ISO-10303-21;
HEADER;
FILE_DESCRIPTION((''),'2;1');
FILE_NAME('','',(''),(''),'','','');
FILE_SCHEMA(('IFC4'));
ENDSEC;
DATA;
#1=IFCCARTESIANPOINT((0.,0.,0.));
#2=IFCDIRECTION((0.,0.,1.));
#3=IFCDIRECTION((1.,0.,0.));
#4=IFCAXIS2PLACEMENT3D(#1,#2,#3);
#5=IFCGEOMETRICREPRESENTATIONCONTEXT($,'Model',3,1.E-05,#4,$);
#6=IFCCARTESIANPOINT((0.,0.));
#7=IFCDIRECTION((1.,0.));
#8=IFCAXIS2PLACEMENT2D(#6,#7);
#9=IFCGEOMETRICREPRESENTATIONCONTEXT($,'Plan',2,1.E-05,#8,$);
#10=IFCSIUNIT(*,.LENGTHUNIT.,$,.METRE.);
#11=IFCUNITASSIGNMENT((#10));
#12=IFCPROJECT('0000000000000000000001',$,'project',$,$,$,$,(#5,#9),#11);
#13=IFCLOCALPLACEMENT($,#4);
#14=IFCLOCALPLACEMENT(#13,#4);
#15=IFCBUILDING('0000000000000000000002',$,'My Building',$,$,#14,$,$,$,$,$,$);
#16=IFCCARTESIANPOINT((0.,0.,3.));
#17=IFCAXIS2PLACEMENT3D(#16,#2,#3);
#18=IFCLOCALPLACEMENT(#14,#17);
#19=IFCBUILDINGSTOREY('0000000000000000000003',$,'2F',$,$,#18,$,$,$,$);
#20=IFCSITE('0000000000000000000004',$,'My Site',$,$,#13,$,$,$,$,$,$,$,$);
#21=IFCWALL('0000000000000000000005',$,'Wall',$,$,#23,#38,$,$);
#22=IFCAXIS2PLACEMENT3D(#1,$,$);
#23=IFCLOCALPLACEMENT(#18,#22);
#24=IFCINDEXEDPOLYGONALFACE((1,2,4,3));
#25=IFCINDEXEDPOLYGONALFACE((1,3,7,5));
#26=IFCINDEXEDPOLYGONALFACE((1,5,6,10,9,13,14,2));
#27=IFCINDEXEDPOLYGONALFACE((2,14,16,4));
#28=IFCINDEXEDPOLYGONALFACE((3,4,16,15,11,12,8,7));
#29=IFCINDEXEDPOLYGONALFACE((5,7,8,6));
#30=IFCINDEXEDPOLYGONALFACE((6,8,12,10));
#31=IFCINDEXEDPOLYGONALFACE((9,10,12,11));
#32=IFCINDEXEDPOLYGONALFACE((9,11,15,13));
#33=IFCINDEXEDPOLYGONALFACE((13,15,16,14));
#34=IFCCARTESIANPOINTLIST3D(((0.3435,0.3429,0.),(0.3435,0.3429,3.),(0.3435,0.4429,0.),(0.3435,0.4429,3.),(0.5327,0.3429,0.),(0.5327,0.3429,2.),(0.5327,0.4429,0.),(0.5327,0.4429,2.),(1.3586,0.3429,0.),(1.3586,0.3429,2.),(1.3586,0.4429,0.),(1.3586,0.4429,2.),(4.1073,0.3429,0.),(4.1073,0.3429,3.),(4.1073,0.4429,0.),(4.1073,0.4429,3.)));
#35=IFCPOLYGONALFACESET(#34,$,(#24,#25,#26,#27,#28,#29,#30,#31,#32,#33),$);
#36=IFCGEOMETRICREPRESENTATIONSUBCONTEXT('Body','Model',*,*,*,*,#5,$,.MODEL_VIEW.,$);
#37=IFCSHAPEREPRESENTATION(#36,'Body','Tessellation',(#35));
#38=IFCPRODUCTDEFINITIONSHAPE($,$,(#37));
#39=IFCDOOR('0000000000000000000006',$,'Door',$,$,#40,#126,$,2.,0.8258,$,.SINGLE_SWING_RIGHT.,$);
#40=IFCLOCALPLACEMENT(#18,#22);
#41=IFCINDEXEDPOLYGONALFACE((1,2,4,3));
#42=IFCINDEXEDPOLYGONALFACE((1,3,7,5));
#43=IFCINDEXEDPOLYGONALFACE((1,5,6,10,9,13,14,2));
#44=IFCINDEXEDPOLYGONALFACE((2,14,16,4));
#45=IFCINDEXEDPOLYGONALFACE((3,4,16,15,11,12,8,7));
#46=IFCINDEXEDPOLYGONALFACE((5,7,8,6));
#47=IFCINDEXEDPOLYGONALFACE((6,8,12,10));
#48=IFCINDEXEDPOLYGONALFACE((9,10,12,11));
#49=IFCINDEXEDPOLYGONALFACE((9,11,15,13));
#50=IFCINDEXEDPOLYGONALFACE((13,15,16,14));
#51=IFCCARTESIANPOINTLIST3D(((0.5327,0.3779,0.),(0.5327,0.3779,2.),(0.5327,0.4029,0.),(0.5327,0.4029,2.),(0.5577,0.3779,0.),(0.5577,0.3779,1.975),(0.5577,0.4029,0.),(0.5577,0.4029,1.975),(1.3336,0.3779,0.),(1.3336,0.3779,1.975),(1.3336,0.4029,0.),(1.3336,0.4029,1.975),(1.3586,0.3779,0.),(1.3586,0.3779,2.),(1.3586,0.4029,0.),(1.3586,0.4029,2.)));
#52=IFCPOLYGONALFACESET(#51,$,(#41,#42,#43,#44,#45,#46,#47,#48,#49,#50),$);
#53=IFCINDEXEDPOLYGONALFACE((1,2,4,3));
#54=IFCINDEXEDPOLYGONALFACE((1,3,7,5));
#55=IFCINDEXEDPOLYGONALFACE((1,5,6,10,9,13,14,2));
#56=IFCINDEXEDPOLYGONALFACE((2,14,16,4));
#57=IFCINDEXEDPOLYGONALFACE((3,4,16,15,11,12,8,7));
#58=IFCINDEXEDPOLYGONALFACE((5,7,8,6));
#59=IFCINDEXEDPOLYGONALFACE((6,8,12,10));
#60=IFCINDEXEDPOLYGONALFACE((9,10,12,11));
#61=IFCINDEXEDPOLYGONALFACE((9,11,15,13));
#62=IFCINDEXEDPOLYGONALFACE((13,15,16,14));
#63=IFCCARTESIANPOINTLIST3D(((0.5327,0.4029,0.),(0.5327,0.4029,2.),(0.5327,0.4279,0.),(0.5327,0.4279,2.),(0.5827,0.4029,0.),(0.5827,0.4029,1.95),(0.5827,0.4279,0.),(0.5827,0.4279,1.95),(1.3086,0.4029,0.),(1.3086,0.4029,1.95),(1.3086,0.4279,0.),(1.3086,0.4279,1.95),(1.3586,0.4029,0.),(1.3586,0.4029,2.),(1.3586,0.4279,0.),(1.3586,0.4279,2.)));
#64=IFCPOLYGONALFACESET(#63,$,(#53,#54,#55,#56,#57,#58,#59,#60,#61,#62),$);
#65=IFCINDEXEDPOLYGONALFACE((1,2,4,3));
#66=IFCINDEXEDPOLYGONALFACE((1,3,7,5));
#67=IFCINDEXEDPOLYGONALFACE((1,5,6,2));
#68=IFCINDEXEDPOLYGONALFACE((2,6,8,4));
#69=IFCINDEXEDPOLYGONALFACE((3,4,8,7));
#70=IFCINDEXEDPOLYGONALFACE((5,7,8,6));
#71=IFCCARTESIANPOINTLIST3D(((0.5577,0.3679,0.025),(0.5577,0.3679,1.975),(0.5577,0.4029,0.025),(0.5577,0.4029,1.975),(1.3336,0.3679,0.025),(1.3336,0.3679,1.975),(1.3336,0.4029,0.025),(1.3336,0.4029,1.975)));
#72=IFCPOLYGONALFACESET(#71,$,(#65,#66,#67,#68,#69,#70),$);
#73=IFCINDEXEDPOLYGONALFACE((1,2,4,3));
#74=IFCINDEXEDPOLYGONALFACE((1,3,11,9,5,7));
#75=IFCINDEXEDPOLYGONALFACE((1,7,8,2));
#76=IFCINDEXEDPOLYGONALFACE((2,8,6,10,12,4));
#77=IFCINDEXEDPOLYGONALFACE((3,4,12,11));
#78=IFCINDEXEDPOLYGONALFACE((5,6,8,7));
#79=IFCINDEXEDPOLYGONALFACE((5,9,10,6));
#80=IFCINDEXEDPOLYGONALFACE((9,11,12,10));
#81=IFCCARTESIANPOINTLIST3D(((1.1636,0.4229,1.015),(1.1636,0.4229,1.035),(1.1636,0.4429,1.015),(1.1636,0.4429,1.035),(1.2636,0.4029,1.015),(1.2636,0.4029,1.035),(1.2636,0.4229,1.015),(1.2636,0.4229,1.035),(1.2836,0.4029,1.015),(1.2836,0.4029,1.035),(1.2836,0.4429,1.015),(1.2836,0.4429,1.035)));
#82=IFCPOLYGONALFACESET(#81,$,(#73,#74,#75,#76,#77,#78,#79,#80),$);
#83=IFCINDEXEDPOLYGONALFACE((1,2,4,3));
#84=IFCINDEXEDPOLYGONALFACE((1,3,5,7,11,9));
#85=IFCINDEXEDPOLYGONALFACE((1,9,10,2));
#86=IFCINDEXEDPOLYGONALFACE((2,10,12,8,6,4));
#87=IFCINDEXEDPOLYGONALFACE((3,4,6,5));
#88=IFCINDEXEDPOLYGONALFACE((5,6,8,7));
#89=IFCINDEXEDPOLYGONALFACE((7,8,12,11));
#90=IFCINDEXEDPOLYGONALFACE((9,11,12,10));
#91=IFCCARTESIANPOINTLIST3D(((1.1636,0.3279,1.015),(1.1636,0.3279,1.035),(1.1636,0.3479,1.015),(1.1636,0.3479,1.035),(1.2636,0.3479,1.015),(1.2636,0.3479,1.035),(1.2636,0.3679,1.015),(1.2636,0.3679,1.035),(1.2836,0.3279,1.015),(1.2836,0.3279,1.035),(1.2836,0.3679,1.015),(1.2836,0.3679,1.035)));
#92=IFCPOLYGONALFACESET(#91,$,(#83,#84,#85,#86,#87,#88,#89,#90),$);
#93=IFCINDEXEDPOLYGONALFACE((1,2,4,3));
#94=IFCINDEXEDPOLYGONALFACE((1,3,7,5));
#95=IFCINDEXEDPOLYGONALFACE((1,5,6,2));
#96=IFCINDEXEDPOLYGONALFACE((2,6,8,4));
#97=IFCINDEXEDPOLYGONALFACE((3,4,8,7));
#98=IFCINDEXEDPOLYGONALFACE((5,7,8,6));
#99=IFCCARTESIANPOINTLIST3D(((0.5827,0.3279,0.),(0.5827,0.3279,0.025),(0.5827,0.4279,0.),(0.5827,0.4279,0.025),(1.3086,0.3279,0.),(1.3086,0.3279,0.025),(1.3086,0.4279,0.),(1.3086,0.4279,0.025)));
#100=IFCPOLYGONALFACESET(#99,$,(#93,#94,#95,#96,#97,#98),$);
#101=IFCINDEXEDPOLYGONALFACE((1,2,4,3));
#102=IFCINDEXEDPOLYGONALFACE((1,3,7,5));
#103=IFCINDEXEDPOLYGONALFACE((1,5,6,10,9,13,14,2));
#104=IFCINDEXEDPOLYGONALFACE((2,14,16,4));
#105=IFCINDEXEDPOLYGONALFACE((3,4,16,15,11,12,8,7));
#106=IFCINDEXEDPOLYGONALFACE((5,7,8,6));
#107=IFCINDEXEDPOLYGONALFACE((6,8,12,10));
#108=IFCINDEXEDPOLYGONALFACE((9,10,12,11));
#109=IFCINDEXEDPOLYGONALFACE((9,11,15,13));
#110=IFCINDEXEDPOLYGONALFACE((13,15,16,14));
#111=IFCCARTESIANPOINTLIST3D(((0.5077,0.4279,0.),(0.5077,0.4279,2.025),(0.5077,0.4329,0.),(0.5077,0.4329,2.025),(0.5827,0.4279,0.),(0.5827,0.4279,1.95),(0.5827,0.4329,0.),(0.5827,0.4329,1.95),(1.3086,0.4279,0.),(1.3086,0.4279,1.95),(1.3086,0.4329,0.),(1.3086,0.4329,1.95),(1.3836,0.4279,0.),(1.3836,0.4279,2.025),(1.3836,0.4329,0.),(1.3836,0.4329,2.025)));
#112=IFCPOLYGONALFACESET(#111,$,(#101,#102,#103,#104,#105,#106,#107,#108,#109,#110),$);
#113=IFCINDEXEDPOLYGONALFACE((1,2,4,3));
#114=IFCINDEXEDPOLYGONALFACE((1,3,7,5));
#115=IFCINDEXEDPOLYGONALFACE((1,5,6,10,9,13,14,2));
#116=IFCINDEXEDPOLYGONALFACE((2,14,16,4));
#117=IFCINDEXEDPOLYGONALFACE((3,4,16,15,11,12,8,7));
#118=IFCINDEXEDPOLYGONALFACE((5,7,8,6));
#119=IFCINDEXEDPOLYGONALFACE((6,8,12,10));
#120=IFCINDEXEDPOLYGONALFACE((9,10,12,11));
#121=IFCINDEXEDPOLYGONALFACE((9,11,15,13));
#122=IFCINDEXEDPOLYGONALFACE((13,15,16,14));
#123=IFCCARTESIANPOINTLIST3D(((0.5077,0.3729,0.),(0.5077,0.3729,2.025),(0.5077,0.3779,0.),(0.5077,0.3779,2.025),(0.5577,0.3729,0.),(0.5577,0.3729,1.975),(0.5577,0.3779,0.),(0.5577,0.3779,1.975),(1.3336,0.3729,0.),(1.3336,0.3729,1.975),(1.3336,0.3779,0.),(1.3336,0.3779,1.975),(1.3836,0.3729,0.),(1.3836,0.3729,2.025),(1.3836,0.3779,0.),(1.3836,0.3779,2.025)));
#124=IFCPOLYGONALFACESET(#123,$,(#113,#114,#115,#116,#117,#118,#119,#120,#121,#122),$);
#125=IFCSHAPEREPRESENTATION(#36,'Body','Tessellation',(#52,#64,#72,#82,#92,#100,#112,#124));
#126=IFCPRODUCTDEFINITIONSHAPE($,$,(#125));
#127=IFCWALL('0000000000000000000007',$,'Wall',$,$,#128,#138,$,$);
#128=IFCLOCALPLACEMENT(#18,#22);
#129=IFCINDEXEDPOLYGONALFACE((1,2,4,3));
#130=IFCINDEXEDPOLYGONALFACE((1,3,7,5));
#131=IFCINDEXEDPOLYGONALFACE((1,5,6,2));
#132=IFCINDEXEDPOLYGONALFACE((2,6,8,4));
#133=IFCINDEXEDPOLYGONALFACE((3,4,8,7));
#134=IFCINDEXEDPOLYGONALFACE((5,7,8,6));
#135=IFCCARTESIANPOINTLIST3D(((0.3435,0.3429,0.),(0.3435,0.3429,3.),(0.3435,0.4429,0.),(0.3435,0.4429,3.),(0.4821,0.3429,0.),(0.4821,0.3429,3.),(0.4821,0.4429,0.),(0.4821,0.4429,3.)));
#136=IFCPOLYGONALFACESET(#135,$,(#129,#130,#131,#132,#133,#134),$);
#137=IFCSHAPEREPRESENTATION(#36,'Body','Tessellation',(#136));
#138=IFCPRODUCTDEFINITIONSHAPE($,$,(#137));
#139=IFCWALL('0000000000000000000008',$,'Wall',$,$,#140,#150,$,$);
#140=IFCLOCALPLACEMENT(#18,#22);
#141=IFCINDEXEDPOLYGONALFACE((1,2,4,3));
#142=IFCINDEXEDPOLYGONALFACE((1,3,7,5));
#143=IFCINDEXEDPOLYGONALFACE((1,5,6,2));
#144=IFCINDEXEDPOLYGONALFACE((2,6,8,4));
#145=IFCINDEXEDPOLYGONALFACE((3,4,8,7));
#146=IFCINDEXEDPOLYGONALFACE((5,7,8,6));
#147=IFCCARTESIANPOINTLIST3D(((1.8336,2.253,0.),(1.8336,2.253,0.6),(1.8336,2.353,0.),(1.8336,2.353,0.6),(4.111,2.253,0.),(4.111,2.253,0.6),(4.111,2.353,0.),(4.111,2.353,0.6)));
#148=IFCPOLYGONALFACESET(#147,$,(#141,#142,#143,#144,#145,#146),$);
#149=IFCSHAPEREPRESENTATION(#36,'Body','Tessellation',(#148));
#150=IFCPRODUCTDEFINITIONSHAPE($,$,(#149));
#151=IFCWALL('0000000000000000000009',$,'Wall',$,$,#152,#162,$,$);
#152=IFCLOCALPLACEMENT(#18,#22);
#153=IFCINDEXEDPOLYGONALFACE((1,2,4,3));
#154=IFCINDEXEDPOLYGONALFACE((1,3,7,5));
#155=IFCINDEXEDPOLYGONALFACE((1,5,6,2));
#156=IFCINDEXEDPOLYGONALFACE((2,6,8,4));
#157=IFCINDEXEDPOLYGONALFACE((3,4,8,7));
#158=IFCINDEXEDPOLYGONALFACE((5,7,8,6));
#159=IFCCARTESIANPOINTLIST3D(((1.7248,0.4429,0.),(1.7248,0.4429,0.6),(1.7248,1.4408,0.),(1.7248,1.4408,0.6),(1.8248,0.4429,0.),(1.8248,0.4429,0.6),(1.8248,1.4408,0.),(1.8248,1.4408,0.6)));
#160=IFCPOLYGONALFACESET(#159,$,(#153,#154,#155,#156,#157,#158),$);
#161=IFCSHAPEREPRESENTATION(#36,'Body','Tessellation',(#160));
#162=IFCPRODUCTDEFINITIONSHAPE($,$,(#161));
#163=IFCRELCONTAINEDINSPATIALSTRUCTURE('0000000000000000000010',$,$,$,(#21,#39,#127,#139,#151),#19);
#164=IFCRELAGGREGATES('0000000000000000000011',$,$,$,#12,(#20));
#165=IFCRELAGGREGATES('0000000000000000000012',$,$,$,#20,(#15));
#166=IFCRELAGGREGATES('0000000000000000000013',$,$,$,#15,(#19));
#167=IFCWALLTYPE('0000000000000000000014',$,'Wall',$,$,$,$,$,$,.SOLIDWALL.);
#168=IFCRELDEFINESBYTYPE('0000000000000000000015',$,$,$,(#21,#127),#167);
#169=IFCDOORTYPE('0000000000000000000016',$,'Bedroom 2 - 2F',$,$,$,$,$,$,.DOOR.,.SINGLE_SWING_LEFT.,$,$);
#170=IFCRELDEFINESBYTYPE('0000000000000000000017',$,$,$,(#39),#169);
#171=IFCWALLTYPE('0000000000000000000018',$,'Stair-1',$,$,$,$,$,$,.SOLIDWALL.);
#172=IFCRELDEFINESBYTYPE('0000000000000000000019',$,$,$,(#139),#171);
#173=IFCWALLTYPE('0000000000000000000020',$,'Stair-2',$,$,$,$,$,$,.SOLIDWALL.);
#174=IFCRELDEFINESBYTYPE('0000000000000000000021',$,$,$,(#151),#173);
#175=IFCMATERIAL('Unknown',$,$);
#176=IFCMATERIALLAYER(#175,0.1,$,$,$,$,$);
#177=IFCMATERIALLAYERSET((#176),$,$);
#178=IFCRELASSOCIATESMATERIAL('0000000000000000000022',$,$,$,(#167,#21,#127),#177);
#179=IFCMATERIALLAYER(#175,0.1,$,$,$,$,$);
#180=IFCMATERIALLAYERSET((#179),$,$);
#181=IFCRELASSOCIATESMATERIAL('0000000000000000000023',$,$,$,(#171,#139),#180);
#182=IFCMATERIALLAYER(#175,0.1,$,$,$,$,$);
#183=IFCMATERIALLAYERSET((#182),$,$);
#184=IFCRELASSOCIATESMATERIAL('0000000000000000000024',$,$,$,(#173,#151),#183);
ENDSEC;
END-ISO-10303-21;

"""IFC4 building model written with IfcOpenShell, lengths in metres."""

from ifc_helpers import new_model, entity, si_unit, frame, origin_with_axes, origin_2d_with_axis, place, context, subcontext, project, spatial, line, indexed_curve, outline, extrude, shape, source, transform, mapped, material, layer, layer_set, layer_usage, type_object, type_shapes, element, fill, save


model = new_model("IFC4")

# Units and contexts
model_context = context("Model", 3, precision=1e-05, world=origin_with_axes())
plan_context = context("Plan", 2, precision=1e-05, world=origin_2d_with_axis())
body_context_1 = subcontext(model_context, "Body", "Model", "MODEL_VIEW")
body_context_2 = subcontext(plan_context, "Body", "Plan", "PLAN_VIEW")
ifc_project = project(units=[si_unit("LENGTHUNIT", "METRE")], contexts=[model_context, plan_context])

# Site, building, storey
site_placement = place(None, origin_with_axes())
site = spatial("IfcSite", under=ifc_project, at=site_placement, Name="My Site")
building_placement = place(site_placement, origin_with_axes())
building = spatial("IfcBuilding", under=site, at=building_placement, Name="My Building")
storey_placement = place(building_placement, frame((0.0, 0.0, 3.0), z_axis=(0.0, 0.0, 1.0), x_axis=(1.0, 0.0, 0.0)))
storey = spatial("IfcBuildingStorey", under=building, at=storey_placement, Name="2F")

# Shared definitions
ifc_material = material(Name="Unknown")

# Shared definitions
ifc_layer_1 = layer(ifc_material, 0.1)
ifc_layer_set_1 = layer_set([ifc_layer_1])
wall_type_1 = type_object("IfcWallType", Name="Wall", PredefinedType="SOLIDWALL", material=ifc_layer_set_1)

# Wall, opening, door
ifc_layer_usage_1 = layer_usage(ifc_layer_set_1, "AXIS2", "POSITIVE", 0.0)
wall_1_placement = place(storey_placement, frame((4.2073, 0.4429, 0.0), z_axis=(0.0, 0.0, 1.0), x_axis=(-1.0, 0.0, 0.0)))
wall_1 = element("IfcWall", 1, at=wall_1_placement, inside=storey, type_object=wall_type_1, material=ifc_layer_usage_1, Name="Wall", context=body_context_1, shape_type="SweptSolid", body=[
    extrude(outline(indexed_curve([(0.1, 0.0), (0.1, 0.1), (3.8638, 0.1), (3.8638, 0.0)], segments=[line(1, 2, 3, 4, 1)])), origin_with_axes(), (0.0, 0.0, 1.0), 3.0),
])
shared_shape_1 = source(origin_with_axes(), body_context_1, "Body", "SweptSolid", [
    extrude(outline(indexed_curve([(0.0, 0.0), (0.8258, 0.0), (0.8258, 2.0), (0.0, 2.0)], segments=[line(1, 2, 3, 4, 1)])), frame((0.0, -0.6, 0.0), z_axis=(0.0, -1.0, 0.0), x_axis=(1.0, 0.0, 0.0)), (0.0, 0.0, -1.0), 1.2),
])
opening_1_placement = place(wall_1_placement, frame((2.8487, 0.015, 0.0), z_axis=(0.0, 0.0, 1.0), x_axis=(1.0, -0.000001, 0.0)))
opening_1 = element("IfcOpeningElement", 2, at=opening_1_placement, cuts=wall_1, PredefinedType="OPENING", context=body_context_1, shape_type="MappedRepresentation", body=[
    mapped(shared_shape_1, transform((0.0, 0.0, 0.0), x_axis=(1.0, 0.0, 0.0), y_axis=(0.0, 1.0, 0.0), z_axis=(0.0, 0.0, 1.0), scale=1.0)),
])
door_type_1 = type_object("IfcDoorType", Name="Bedroom 2 - 2F", OperationType="SINGLE_SWING_LEFT", PredefinedType="DOOR")
shared_shape_2 = source(origin_with_axes(), body_context_1, "Body", "SweptSolid", [
    extrude(outline(indexed_curve([(0.0, 0.0), (0.0, 2.0), (0.8258, 2.0), (0.8258, 0.0), (0.8008, 0.0), (0.8008, 1.975), (0.025, 1.975), (0.025, 0.0)], segments=[line(1, 2, 3, 4, 5, 6, 7, 8, 1)])), frame((0.0, 0.025, 0.0), z_axis=(0.0, -1.0, 0.0), x_axis=(1.0, 0.0, 0.0)), (0.0, 0.0, -1.0), 0.025),
    extrude(outline(indexed_curve([(0.0, 0.0), (0.0, 2.0), (0.8258, 2.0), (0.8258, 0.0), (0.7758, 0.0), (0.7758, 1.95), (0.05, 1.95), (0.05, 0.0)], segments=[line(1, 2, 3, 4, 5, 6, 7, 8, 1)])), frame((0.0, 0.0, 0.0), z_axis=(0.0, -1.0, 0.0), x_axis=(1.0, 0.0, 0.0)), (0.0, 0.0, -1.0), 0.025),
    extrude(outline(indexed_curve([(0.0, 0.0), (0.7758, 0.0), (0.7758, 0.035), (0.0, 0.035)], segments=[line(1, 2, 3, 4, 1)])), frame((0.025, 0.025, 0.025), z_axis=(0.0, 0.0, 1.0), x_axis=(1.0, 0.0, 0.0)), (0.0, 0.0, 1.0), 1.95),
    extrude(outline(indexed_curve([(0.0, 0.0), (0.0, -0.04), (0.12, -0.04), (0.12, -0.02), (0.02, -0.02), (0.02, 0.0)], segments=[line(1, 2, 3, 4, 5, 6, 1)])), frame((0.075, 0.025, 1.015), z_axis=(0.0, 0.0, 1.0), x_axis=(1.0, 0.0, 0.0)), (0.0, 0.0, 1.0), 0.02),
    extrude(outline(indexed_curve([(0.0, 0.0), (0.0, 0.04), (0.12, 0.04), (0.12, 0.02), (0.02, 0.02), (0.02, 0.0)], segments=[line(1, 2, 3, 4, 5, 6, 1)])), frame((0.075, 0.06, 1.015), z_axis=(0.0, 0.0, 1.0), x_axis=(1.0, 0.0, 0.0)), (0.0, 0.0, 1.0), 0.02),
    extrude(outline(indexed_curve([(0.0, 0.0), (0.7258, 0.0), (0.7258, 0.1), (0.0, 0.1)], segments=[line(1, 2, 3, 4, 1)])), frame((0.05, 0.0, 0.0), z_axis=(0.0, 0.0, 1.0), x_axis=(1.0, 0.0, 0.0)), (0.0, 0.0, 1.0), 0.025),
    extrude(outline(indexed_curve([(0.0, 0.0), (0.0, 2.025), (0.8758, 2.025), (0.8758, 0.0), (0.8008, 0.0), (0.8008, 1.95), (0.075, 1.95), (0.075, 0.0)], segments=[line(1, 2, 3, 4, 5, 6, 7, 8, 1)])), frame((-0.025, -0.005, 0.0), z_axis=(0.0, -1.0, 0.0), x_axis=(1.0, 0.0, 0.0)), (0.0, 0.0, -1.0), 0.005),
    extrude(outline(indexed_curve([(0.0, 0.0), (0.0, 2.025), (0.8758, 2.025), (0.8758, 0.0), (0.8258, 0.0), (0.8258, 1.975), (0.05, 1.975), (0.05, 0.0)], segments=[line(1, 2, 3, 4, 5, 6, 7, 8, 1)])), frame((-0.025, 0.05, 0.0), z_axis=(0.0, -1.0, 0.0), x_axis=(1.0, 0.0, 0.0)), (0.0, 0.0, -1.0), 0.005),
])
shared_shape_3 = source(origin_with_axes(), body_context_2, "Body", "Curve2D", [
    entity("IfcIndexedPolyCurve", entity("IfcCartesianPointList2D", [[0.0, 0.0], [0.0, 0.05], [0.025, 0.05], [0.025, 0.025], [0.05, 0.025], [0.05, 0.0]]), [entity("IfcLineIndex", [1, 2, 3, 4, 5, 6, 1])]),
    entity("IfcIndexedPolyCurve", entity("IfcCartesianPointList2D", [[0.8258, 0.0], [0.8258, 0.05], [0.8008, 0.05], [0.8008, 0.025], [0.7758, 0.025], [0.7758, 0.0]]), [entity("IfcLineIndex", [1, 2, 3, 4, 5, 6, 1])]),
    entity("IfcTrimmedCurve", entity("IfcEllipse", entity("IfcAxis2Placement2D", entity("IfcCartesianPoint", [0.7658, 0.05]), entity("IfcDirection", [1.0, 0.0])), 0.7408, 0.7758), [entity("IfcCartesianPoint", [0.7658, 0.8258])], [entity("IfcCartesianPoint", [0.025, 0.05])], True, "CARTESIAN"),
    entity("IfcIndexedPolyCurve", entity("IfcCartesianPointList2D", [[0.8008, 0.05], [0.7658, 0.05], [0.7658, 0.8258], [0.8008, 0.8258]]), [entity("IfcLineIndex", [1, 2, 3, 4, 1])]),
])
type_shapes(door_type_1, [shared_shape_2, shared_shape_3])
door_1_placement = place(opening_1_placement, frame((0.0, 0.0, 0.0), z_axis=(0.0, 0.0, 1.0), x_axis=(1.0, 0.0, 0.0)))
door_1 = element("IfcDoor", 3, at=door_1_placement, inside=storey, type_object=door_type_1, Name="Door", OperationType="SINGLE_SWING_RIGHT", OverallHeight=2.0, OverallWidth=0.8258, shapes=[
    shape(body_context_1, "Body", "MappedRepresentation", [mapped(shared_shape_2, transform((0.0, 0.0, 0.0), x_axis=(1.0, 0.0, 0.0), y_axis=(0.0, 1.0, 0.0), z_axis=(0.0, 0.0, 1.0), scale=1.0))]),
    shape(body_context_2, "Body", "MappedRepresentation", [mapped(shared_shape_3, transform((0.0, 0.0, 0.0), x_axis=(1.0, 0.0, 0.0), y_axis=(0.0, 1.0, 0.0), z_axis=(0.0, 0.0, 1.0), scale=1.0))]),
])
fill(opening_1, door_1)

# Walls
ifc_layer_usage_2 = layer_usage(ifc_layer_set_1, "AXIS2", "POSITIVE", 0.0)
wall_2_placement = place(storey_placement, frame((0.4821, 0.4429, 0.0), z_axis=(0.0, 0.0, 1.0), x_axis=(-1.0, 0.0, 0.0)))
element("IfcWall", 4, at=wall_2_placement, inside=storey, type_object=wall_type_1, material=ifc_layer_usage_2, Name="Wall", context=body_context_1, shape_type="SweptSolid", body=[
    extrude(outline(indexed_curve([(0.0, 0.0), (0.0, 0.1), (0.1387, 0.1), (0.1387, 0.0)], segments=[line(1, 2, 3, 4, 1)])), origin_with_axes(), (0.0, 0.0, 1.0), 3.0),
])
ifc_layer_2 = layer(ifc_material, 0.1)
ifc_layer_set_2 = layer_set([ifc_layer_2])
ifc_layer_usage_3 = layer_usage(ifc_layer_set_2, "AXIS2", "POSITIVE", 0.0)
wall_type_2 = type_object("IfcWallType", Name="Stair-1", PredefinedType="SOLIDWALL", material=ifc_layer_set_2)
wall_3_placement = place(storey_placement, frame((1.8336, 2.253, 0.0), z_axis=(0.0, 0.0, 1.0), x_axis=(1.0, 0.0, 0.0)))
element("IfcWall", 5, at=wall_3_placement, inside=storey, type_object=wall_type_2, material=ifc_layer_usage_3, Name="Wall", context=body_context_1, shape_type="SweptSolid", body=[
    extrude(outline(indexed_curve([(0.0, 0.0), (0.0, 0.1), (2.2773, 0.1), (2.2773, 0.0)], segments=[line(1, 2, 3, 4, 1)])), origin_with_axes(), (0.0, 0.0, 1.0), 0.6),
])
ifc_layer_3 = layer(ifc_material, 0.1)
ifc_layer_set_3 = layer_set([ifc_layer_3])
ifc_layer_usage_4 = layer_usage(ifc_layer_set_3, "AXIS2", "POSITIVE", 0.0)
wall_type_3 = type_object("IfcWallType", Name="Stair-2", PredefinedType="SOLIDWALL", material=ifc_layer_set_3)
wall_4_placement = place(storey_placement, frame((1.8248, 0.4429, 0.0), z_axis=(0.0, 0.0, 1.0), x_axis=(0.0, 1.0, 0.0)))
element("IfcWall", 6, at=wall_4_placement, inside=storey, type_object=wall_type_3, material=ifc_layer_usage_4, Name="Wall", context=body_context_1, shape_type="SweptSolid", body=[
    extrude(outline(indexed_curve([(0.0, 0.0), (0.0, 0.1), (0.9979, 0.1), (0.9979, 0.0)], segments=[line(1, 2, 3, 4, 1)])), origin_with_axes(), (0.0, 0.0, 1.0), 0.6),
])

save(model, "model.ifc")
